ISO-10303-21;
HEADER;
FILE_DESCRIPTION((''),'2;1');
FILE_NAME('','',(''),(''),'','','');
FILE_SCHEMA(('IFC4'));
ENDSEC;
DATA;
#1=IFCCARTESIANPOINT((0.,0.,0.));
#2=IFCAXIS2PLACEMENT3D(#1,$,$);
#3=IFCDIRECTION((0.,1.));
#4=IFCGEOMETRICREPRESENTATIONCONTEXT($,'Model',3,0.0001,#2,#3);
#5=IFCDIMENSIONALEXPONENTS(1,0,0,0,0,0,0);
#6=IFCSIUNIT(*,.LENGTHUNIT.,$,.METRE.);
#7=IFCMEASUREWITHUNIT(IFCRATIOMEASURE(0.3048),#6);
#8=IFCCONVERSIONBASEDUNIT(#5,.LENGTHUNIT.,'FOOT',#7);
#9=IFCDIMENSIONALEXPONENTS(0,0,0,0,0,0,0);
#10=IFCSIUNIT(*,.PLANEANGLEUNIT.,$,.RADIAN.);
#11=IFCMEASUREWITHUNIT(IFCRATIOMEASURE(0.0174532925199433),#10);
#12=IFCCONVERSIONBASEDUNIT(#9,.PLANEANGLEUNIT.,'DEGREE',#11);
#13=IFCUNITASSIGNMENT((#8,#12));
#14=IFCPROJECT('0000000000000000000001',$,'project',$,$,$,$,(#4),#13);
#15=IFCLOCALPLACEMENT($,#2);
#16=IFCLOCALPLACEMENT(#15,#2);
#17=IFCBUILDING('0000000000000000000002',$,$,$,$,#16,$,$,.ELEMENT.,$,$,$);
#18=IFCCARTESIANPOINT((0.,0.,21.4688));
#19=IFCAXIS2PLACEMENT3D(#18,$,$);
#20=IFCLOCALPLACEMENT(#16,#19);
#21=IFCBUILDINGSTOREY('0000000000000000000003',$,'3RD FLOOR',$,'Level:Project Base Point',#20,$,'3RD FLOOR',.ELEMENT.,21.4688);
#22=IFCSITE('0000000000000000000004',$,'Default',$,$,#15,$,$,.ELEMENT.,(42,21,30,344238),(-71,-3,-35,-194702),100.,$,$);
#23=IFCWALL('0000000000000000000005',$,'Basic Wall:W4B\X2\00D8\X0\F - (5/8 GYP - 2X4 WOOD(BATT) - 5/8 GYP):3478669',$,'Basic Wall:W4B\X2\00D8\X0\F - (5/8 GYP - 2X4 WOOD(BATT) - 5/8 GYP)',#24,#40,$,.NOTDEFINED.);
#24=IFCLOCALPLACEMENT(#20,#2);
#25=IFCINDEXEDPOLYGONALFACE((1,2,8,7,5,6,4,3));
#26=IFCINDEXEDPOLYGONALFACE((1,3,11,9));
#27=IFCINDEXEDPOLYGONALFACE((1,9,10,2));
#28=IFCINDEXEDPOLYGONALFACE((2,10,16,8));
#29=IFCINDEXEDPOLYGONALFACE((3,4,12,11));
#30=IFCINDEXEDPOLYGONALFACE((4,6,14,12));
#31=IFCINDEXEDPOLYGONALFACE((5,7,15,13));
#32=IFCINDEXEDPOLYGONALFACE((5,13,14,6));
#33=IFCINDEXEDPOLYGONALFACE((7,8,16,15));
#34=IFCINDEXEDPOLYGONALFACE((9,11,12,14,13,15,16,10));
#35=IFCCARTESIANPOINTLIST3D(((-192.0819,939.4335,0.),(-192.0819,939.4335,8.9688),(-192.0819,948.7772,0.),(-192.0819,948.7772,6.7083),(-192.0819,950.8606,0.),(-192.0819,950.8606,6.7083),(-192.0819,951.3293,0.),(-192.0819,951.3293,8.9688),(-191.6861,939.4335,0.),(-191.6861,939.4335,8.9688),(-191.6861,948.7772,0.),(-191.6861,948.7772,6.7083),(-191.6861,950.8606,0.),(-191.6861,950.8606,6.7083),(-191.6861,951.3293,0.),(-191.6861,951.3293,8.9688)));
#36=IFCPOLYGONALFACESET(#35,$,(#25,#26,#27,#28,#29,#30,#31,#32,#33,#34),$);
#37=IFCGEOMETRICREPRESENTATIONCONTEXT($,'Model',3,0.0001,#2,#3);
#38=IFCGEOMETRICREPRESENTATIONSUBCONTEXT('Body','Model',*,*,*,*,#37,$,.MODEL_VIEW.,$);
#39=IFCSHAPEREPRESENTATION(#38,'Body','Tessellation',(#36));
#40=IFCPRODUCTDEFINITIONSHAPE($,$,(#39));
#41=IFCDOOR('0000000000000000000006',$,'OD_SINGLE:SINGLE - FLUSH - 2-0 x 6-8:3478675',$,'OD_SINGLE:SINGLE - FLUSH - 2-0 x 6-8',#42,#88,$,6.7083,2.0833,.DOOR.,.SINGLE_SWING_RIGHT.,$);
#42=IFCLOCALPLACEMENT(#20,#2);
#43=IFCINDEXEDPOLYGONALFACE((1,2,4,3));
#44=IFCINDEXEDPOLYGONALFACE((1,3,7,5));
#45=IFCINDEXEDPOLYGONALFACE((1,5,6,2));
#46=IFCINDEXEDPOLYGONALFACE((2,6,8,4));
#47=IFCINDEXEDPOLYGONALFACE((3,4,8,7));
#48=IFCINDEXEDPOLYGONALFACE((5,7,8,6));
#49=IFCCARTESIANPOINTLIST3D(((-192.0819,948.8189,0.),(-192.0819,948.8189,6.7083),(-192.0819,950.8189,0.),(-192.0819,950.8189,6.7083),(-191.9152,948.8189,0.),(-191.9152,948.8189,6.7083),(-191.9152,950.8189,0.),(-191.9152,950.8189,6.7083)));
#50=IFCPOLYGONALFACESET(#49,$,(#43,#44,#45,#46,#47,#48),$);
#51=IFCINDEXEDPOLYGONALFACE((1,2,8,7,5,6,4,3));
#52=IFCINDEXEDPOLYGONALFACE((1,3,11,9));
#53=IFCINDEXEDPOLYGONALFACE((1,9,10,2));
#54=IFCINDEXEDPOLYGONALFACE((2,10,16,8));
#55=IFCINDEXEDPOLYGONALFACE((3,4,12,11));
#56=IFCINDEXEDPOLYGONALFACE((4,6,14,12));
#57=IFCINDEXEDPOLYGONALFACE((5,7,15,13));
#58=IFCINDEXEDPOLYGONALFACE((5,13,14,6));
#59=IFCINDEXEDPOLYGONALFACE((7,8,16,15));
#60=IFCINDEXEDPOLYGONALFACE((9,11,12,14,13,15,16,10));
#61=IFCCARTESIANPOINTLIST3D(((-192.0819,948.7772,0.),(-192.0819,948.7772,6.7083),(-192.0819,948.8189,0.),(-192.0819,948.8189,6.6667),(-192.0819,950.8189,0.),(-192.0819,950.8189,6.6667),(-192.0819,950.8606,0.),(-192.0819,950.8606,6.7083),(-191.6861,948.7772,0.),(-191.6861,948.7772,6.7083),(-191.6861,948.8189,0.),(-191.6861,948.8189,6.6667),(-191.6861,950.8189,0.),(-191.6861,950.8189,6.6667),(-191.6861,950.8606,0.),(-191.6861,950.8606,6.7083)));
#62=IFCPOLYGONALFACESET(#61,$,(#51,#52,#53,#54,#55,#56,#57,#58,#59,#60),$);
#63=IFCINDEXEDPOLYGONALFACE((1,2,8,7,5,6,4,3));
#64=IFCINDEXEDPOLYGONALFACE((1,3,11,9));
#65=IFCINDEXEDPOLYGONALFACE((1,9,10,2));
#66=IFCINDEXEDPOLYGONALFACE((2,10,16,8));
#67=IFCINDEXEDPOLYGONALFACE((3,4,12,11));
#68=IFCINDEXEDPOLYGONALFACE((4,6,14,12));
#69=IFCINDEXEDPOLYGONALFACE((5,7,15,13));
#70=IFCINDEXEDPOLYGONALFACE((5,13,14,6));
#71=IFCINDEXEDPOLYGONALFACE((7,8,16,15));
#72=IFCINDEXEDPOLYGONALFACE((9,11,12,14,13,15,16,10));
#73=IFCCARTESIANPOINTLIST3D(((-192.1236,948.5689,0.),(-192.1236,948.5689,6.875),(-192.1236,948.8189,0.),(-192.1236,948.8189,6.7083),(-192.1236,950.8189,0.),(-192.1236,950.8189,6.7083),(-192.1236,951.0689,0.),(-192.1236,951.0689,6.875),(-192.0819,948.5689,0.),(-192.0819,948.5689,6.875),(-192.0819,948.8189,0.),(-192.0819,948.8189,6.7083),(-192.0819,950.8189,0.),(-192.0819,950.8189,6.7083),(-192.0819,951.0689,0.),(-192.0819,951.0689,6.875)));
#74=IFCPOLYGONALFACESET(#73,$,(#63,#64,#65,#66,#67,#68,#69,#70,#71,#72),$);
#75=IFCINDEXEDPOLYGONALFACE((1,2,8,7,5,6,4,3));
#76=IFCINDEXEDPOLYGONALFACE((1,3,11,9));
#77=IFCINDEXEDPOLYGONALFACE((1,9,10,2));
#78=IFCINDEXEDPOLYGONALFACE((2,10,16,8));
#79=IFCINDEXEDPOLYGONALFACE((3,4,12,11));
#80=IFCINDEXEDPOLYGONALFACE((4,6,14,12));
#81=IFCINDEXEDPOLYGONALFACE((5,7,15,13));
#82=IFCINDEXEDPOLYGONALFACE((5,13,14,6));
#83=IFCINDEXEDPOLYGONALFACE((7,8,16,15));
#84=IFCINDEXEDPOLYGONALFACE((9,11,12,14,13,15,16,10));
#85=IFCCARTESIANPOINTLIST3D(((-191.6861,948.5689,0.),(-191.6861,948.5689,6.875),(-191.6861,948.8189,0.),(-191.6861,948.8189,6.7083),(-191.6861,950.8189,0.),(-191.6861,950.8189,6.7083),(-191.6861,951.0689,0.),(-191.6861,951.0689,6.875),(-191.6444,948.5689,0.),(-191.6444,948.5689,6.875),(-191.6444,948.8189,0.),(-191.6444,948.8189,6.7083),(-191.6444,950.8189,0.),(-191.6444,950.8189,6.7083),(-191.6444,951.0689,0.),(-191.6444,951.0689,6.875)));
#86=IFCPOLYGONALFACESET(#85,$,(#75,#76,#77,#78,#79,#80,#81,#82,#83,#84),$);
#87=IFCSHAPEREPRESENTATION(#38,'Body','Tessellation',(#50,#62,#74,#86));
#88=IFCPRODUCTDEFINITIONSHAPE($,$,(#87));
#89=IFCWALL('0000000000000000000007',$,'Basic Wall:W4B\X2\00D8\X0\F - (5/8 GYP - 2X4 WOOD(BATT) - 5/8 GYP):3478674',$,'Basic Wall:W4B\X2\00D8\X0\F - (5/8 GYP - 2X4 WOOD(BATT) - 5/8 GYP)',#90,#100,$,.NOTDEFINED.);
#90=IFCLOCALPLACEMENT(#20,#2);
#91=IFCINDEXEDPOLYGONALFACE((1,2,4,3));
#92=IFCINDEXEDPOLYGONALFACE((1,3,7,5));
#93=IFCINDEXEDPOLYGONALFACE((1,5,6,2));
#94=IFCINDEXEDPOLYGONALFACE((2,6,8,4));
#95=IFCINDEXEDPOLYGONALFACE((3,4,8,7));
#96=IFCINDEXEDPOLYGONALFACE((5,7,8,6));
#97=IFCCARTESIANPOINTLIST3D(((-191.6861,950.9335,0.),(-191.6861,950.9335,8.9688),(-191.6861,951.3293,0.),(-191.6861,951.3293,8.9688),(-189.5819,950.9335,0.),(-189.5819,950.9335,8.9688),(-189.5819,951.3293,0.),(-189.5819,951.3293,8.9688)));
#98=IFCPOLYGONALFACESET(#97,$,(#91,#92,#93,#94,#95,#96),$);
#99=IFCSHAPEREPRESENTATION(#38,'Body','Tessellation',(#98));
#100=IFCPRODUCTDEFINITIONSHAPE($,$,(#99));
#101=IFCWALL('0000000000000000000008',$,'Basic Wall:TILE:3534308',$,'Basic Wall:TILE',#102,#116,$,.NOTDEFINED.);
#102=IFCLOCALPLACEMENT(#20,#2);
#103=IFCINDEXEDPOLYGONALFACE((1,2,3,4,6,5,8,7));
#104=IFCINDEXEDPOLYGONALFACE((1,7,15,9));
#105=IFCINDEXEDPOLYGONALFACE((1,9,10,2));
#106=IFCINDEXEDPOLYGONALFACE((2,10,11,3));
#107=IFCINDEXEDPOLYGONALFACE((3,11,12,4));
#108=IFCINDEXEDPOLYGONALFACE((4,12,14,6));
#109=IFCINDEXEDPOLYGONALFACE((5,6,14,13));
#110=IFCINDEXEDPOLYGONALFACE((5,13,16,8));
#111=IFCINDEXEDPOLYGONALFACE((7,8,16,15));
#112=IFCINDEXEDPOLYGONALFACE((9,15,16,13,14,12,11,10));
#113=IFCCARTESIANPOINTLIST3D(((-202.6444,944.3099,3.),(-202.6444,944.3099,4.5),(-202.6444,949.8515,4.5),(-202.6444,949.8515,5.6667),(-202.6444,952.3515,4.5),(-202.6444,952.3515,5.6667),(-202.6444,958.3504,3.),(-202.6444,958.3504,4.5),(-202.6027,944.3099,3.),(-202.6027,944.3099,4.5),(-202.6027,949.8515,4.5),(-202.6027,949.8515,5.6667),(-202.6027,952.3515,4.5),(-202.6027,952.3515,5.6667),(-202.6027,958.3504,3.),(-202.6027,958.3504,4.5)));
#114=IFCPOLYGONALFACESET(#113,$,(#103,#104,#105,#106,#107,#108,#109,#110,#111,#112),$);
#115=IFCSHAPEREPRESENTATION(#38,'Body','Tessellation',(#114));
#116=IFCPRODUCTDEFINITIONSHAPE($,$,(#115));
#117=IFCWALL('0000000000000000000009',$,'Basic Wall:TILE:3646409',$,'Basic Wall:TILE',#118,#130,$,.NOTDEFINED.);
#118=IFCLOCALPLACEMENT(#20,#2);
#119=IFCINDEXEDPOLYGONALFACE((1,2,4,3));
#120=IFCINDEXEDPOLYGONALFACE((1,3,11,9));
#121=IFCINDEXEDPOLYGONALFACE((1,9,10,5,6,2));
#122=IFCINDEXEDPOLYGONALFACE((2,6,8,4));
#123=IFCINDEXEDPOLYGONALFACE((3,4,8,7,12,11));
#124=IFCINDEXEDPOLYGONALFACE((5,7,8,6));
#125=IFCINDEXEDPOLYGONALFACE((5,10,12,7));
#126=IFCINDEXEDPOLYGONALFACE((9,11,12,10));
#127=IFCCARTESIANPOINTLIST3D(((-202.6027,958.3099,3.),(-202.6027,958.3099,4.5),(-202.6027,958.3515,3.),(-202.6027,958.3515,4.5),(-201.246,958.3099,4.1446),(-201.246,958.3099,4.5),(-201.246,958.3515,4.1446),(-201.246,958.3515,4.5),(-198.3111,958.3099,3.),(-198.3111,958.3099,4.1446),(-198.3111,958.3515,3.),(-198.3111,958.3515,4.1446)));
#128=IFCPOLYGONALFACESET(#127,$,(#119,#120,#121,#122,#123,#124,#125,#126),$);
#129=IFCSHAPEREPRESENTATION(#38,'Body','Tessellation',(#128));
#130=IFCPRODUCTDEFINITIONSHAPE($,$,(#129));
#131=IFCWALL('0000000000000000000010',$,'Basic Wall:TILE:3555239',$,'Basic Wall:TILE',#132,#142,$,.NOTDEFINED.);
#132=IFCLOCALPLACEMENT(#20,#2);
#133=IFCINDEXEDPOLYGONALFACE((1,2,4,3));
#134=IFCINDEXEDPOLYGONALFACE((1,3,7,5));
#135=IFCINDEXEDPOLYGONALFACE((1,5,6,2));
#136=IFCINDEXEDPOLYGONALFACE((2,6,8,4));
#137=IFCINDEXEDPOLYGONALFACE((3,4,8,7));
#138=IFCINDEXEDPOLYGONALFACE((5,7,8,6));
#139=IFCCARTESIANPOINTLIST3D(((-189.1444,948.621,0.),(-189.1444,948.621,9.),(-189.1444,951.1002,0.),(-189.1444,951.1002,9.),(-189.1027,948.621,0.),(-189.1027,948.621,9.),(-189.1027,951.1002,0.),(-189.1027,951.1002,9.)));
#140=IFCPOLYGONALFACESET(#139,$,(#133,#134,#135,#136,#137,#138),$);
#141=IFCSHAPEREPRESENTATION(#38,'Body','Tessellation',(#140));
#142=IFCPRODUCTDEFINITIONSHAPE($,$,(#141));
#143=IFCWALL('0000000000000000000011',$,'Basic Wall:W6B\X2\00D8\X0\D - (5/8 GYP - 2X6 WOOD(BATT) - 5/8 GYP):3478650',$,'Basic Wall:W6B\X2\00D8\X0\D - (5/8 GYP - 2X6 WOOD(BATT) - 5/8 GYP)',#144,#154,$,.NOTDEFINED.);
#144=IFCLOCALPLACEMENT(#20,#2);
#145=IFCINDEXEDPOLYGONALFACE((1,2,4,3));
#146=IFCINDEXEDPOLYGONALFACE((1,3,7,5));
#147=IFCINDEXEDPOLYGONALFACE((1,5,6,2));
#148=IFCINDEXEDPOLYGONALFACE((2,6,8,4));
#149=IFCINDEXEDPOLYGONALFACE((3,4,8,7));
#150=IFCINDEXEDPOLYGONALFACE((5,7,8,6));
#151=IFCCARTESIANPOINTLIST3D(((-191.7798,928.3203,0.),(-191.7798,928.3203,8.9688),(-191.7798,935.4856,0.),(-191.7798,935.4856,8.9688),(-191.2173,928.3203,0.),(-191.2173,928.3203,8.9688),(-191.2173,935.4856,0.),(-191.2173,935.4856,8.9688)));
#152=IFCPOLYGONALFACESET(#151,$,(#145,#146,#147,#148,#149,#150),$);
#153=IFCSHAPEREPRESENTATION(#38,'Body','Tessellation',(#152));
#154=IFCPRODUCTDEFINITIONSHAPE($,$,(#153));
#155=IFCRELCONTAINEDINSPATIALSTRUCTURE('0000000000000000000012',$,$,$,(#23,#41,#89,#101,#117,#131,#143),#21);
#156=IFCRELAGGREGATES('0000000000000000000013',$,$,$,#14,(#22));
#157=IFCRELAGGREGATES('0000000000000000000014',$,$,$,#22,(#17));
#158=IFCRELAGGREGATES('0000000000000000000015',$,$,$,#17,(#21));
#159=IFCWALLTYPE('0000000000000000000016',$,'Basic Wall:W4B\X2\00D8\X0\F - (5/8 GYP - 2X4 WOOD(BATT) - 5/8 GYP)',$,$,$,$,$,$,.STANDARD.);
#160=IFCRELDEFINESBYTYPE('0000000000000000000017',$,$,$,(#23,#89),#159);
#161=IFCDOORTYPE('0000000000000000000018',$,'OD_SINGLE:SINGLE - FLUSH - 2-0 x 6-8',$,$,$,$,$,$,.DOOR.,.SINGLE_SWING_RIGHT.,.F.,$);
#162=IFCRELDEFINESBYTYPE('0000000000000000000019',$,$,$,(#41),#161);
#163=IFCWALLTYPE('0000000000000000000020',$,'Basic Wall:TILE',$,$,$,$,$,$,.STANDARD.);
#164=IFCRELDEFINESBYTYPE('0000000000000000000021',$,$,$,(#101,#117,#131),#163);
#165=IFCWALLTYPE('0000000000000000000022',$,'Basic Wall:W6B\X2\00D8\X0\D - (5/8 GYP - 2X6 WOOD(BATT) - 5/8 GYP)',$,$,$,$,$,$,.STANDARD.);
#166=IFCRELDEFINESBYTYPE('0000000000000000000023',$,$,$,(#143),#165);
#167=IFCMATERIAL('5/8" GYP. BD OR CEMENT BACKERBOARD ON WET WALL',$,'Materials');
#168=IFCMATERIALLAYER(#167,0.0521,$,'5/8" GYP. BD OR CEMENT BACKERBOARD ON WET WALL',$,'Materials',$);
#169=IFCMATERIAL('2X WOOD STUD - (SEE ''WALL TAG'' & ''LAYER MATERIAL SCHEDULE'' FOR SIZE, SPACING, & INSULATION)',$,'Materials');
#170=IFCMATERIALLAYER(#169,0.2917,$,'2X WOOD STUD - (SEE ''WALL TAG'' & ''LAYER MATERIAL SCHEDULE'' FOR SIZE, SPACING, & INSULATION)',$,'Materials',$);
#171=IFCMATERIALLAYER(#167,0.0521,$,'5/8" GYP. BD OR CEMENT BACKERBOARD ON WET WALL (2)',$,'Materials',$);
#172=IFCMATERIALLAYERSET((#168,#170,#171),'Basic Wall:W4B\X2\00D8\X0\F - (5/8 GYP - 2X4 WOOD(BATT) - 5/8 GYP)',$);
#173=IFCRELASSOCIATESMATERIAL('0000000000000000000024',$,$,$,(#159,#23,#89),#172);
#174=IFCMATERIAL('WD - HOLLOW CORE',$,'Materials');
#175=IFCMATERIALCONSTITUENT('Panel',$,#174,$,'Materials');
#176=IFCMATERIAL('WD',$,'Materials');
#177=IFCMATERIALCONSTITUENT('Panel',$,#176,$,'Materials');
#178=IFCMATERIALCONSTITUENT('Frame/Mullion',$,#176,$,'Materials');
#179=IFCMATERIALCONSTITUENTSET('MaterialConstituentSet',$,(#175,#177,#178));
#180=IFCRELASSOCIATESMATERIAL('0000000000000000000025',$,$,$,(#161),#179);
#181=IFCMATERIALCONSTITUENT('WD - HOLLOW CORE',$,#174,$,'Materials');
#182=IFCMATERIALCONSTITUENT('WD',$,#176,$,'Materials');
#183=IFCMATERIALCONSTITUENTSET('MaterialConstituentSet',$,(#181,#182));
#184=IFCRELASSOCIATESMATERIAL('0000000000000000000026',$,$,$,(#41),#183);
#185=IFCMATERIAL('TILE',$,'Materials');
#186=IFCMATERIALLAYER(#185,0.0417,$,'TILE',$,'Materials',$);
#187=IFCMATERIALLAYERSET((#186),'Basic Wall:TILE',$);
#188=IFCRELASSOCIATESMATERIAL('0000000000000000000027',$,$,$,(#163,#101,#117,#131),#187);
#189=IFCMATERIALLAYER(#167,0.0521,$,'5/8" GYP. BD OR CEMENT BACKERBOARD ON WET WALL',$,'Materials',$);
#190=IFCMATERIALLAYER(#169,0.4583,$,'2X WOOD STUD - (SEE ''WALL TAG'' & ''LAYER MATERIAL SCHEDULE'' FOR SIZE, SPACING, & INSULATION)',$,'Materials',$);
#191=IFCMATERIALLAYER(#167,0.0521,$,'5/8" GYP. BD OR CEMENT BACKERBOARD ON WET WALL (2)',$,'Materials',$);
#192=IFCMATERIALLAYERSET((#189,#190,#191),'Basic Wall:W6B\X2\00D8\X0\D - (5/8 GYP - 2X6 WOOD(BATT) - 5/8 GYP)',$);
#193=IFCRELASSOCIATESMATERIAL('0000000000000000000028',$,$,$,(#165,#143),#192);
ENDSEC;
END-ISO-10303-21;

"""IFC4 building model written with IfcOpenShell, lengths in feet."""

from ifc_helpers import new_model, entity, si_unit, converted_unit, direction, frame, frame_2d, origin, origin_2d_with_axis, place, context, subcontext, project, spatial, polyline, rectangle, outline, extrude, source, transform, mapped, material, layer, layer_set, layer_usage, constituent, constituent_set, type_object, type_shapes, element, fill, save


model = new_model("IFC4")

# Units and contexts
model_context_1 = context("Model", 3, precision=0.0001, world=origin(), true_north=direction((0.0, 1.0)))
model_context_2 = context("Model", 3, precision=0.0001, world=origin(), true_north=direction((0.0, 1.0)))
body_context = subcontext(model_context_2, "Body", "Model", "MODEL_VIEW")
ifc_project = project(units=[converted_unit("LENGTHUNIT", "FOOT", entity("IfcRatioMeasure", 0.3048), si_unit("LENGTHUNIT", "METRE"), dimensions=[1, 0, 0, 0, 0, 0, 0]), converted_unit("PLANEANGLEUNIT", "DEGREE", entity("IfcRatioMeasure", 0.0174532925199433), si_unit("PLANEANGLEUNIT", "RADIAN"), dimensions=[0, 0, 0, 0, 0, 0, 0])], contexts=[model_context_1])

# Site, building, storey
site_placement = place(None, origin())
site = spatial("IfcSite", under=ifc_project, at=site_placement, Name="Default", CompositionType="ELEMENT", RefLatitude=(42, 21, 30, 344238), RefLongitude=(-71, -3, -35, -194702), RefElevation=100.0)
building_placement = place(site_placement, origin())
building = spatial("IfcBuilding", under=site, at=building_placement, CompositionType="ELEMENT")
storey_placement = place(building_placement, frame((0.0, 0.0, 21.4688)))
storey = spatial("IfcBuildingStorey", under=building, at=storey_placement, Name="3RD FLOOR", ObjectType="Level:Project Base Point", LongName="3RD FLOOR", CompositionType="ELEMENT", Elevation=21.4688)

# Wall, opening, door
ifc_material_1 = material(Name="5/8\" GYP. BD OR CEMENT BACKERBOARD ON WET WALL", Category="Materials")
ifc_layer_1 = layer(ifc_material_1, 0.0521, Name="5/8\" GYP. BD OR CEMENT BACKERBOARD ON WET WALL", Category="Materials")
ifc_material_2 = material(Name="2X WOOD STUD - (SEE 'WALL TAG' & 'LAYER MATERIAL SCHEDULE' FOR SIZE, SPACING, & INSULATION)", Category="Materials")
ifc_layer_2 = layer(ifc_material_2, 0.2917, Name="2X WOOD STUD - (SEE 'WALL TAG' & 'LAYER MATERIAL SCHEDULE' FOR SIZE, SPACING, & INSULATION)", Category="Materials")
ifc_layer_3 = layer(ifc_material_1, 0.0521, Name="5/8\" GYP. BD OR CEMENT BACKERBOARD ON WET WALL (2)", Category="Materials")
ifc_layer_set_1 = layer_set([ifc_layer_1, ifc_layer_2, ifc_layer_3], Name="Basic Wall:W4BØF - (5/8 GYP - 2X4 WOOD(BATT) - 5/8 GYP)")
ifc_layer_usage_1 = layer_usage(ifc_layer_set_1, "AXIS2", "NEGATIVE", 0.1979)
wall_type_1 = type_object("IfcWallType", Name="Basic Wall:W4BØF - (5/8 GYP - 2X4 WOOD(BATT) - 5/8 GYP)", PredefinedType="STANDARD", material=ifc_layer_set_1)
wall_1_placement = place(storey_placement, frame((-191.884, 939.4335, 0.0), z_axis=(0.0, 0.0, 1.0), x_axis=(0.0, 1.0, 0.0)))
wall_1 = element("IfcWall", 1, at=wall_1_placement, inside=storey, type_object=wall_type_1, material=ifc_layer_usage_1, Name="Basic Wall:W4BØF - (5/8 GYP - 2X4 WOOD(BATT) - 5/8 GYP):3478669", ObjectType="Basic Wall:W4BØF - (5/8 GYP - 2X4 WOOD(BATT) - 5/8 GYP)", PredefinedType="NOTDEFINED", context=body_context, shape_type="SweptSolid", body=[
    extrude(rectangle(XDim=11.8958, YDim=0.3958, at=frame_2d((5.9479, 0.0), x_axis=(-1.0, 0.0))), origin(), (0.0, 0.0, 1.0), 8.9688),
])
opening_1_placement = place(wall_1_placement, frame((9.3438, -0.1979, 0.0)))
opening_1 = element("IfcOpeningElement", 2, at=opening_1_placement, cuts=wall_1, PredefinedType="OPENING", context=body_context, shape_type="SweptSolid", body=[
    extrude(rectangle(XDim=2.0833, YDim=6.7083, at=frame_2d((3.3542, 1.0417), x_axis=(0.0, 1.0))), frame((0.0, 0.0, 0.0), z_axis=(0.0, 1.0, 0.0), x_axis=(0.0, 0.0, 1.0)), (0.0, 0.0, 1.0), 0.3958),
])
ifc_material_3 = material(Name="WD - HOLLOW CORE", Category="Materials")
ifc_constituent_1 = constituent(ifc_material_3, Name="WD - HOLLOW CORE", Category="Materials")
ifc_material_4 = material(Name="WD", Category="Materials")
ifc_constituent_2 = constituent(ifc_material_4, Name="WD", Category="Materials")
ifc_constituent_set_1 = constituent_set(constituents=[ifc_constituent_1, ifc_constituent_2], Name="MaterialConstituentSet")
ifc_constituent_3 = constituent(ifc_material_3, Name="Panel", Category="Materials")
ifc_constituent_4 = constituent(ifc_material_4, Name="Panel", Category="Materials")
ifc_constituent_5 = constituent(ifc_material_4, Name="Frame/Mullion", Category="Materials")
ifc_constituent_set_2 = constituent_set(constituents=[ifc_constituent_3, ifc_constituent_4, ifc_constituent_5], Name="MaterialConstituentSet")
door_type_1 = type_object("IfcDoorType", Name="OD_SINGLE:SINGLE - FLUSH - 2-0 x 6-8", OperationType="SINGLE_SWING_RIGHT", ParameterTakesPrecedence=False, PredefinedType="DOOR", material=ifc_constituent_set_2)
shared_shape_1 = source(origin(), body_context, "Body", "SweptSolid", [
    extrude(rectangle(XDim=0.1667, YDim=2.0, at=origin_2d_with_axis()), frame((1.0417, 0.3125, 0.0), z_axis=(0.0, 0.0, 1.0), x_axis=(0.0, 1.0, 0.0)), (0.0, 0.0, 1.0), 6.7083),
    extrude(outline(polyline([(-3.3646, -1.0417), (3.3438, -1.0417), (3.3438, -1.0), (-3.3229, -1.0), (-3.3229, 1.0), (3.3438, 1.0), (3.3438, 1.0417), (-3.3646, 1.0417), (-3.3646, -1.0417)])), frame((1.0417, 0.0, 3.3438), z_axis=(0.0, 1.0, 0.0), x_axis=(0.0, 0.0, -1.0)), (0.0, 0.0, 1.0), 0.3958),
    extrude(outline(polyline([(-1.25, -3.4792), (1.25, -3.4792), (1.25, 3.3958), (1.0, 3.3958), (1.0, -3.3125), (-1.0, -3.3125), (-1.0, 3.3958), (-1.25, 3.3958), (-1.25, -3.4792)])), frame((1.0417, 0.3958, 3.3958), z_axis=(0.0, 1.0, 0.0), x_axis=(1.0, 0.0, 0.0)), (0.0, 0.0, 1.0), 0.0417),
    extrude(outline(polyline([(-3.4792, -1.25), (3.3958, -1.25), (3.3958, -1.0), (-3.3125, -1.0), (-3.3125, 1.0), (3.3958, 1.0), (3.3958, 1.25), (-3.4792, 1.25), (-3.4792, -1.25)])), frame((1.0417, -0.0417, 3.3958), z_axis=(0.0, 1.0, 0.0), x_axis=(0.0, 0.0, -1.0)), (0.0, 0.0, 1.0), 0.0417),
])
type_shapes(door_type_1, [shared_shape_1])
door_1_placement = place(opening_1_placement, origin())
door_1 = element("IfcDoor", 3, at=door_1_placement, inside=storey, type_object=door_type_1, material=ifc_constituent_set_1, Name="OD_SINGLE:SINGLE - FLUSH - 2-0 x 6-8:3478675", ObjectType="OD_SINGLE:SINGLE - FLUSH - 2-0 x 6-8", OperationType="SINGLE_SWING_RIGHT", OverallHeight=6.7083, OverallWidth=2.0833, PredefinedType="DOOR", context=body_context, shape_type="MappedRepresentation", body=[
    mapped(shared_shape_1, transform((0.0, 0.0, 0.0), scale=1.0)),
])
fill(opening_1, door_1)

# Wall
ifc_layer_usage_2 = layer_usage(ifc_layer_set_1, "AXIS2", "POSITIVE", -0.1979)
wall_2_placement = place(storey_placement, frame((-189.5819, 951.1314, 0.0), z_axis=(0.0, 0.0, 1.0), x_axis=(-1.0, 0.0, 0.0)))
element("IfcWall", 4, at=wall_2_placement, inside=storey, type_object=wall_type_1, material=ifc_layer_usage_2, Name="Basic Wall:W4BØF - (5/8 GYP - 2X4 WOOD(BATT) - 5/8 GYP):3478674", ObjectType="Basic Wall:W4BØF - (5/8 GYP - 2X4 WOOD(BATT) - 5/8 GYP)", PredefinedType="NOTDEFINED", context=body_context, shape_type="SweptSolid", body=[
    extrude(rectangle(XDim=2.1042, YDim=0.3958, at=frame_2d((1.0521, 0.0), x_axis=(-1.0, 0.0))), origin(), (0.0, 0.0, 1.0), 8.9688),
])

# Wall, openings
ifc_material_5 = material(Name="TILE", Category="Materials")
ifc_layer_4 = layer(ifc_material_5, 0.0417, Name="TILE", Category="Materials")
ifc_layer_set_2 = layer_set([ifc_layer_4], Name="Basic Wall:TILE")
ifc_layer_usage_3 = layer_usage(ifc_layer_set_2, "AXIS2", "POSITIVE", -0.0208)
wall_type_2 = type_object("IfcWallType", Name="Basic Wall:TILE", PredefinedType="STANDARD", material=ifc_layer_set_2)
wall_3_placement = place(storey_placement, frame((-202.6236, 958.3504, 3.0), z_axis=(0.0, 0.0, 1.0), x_axis=(0.0, -1.0, 0.0)))
wall_3 = element("IfcWall", 5, at=wall_3_placement, inside=storey, type_object=wall_type_2, material=ifc_layer_usage_3, Name="Basic Wall:TILE:3534308", ObjectType="Basic Wall:TILE", PredefinedType="NOTDEFINED", context=body_context, shape_type="SweptSolid", body=[
    extrude(rectangle(XDim=14.0406, YDim=0.0417, at=frame_2d((7.0203, 0.0), x_axis=(-1.0, 0.0))), origin(), (0.0, 0.0, 1.0), 2.6667),
])
opening_2_placement = place(wall_3_placement, origin())
element("IfcOpeningElement", 6, at=opening_2_placement, cuts=wall_3, PredefinedType="OPENING", context=body_context, shape_type="SweptSolid", body=[
    extrude(rectangle(XDim=1.1667, YDim=5.9989, at=frame_2d((0.0, 0.0), x_axis=(0.0, 1.0))), frame((2.9994, 0.0208, 2.0833), z_axis=(0.0, -1.0, 0.0), x_axis=(-1.0, 0.0, 0.0)), (0.0, 0.0, 1.0), 0.0417),
])
opening_3_placement = place(wall_3_placement, origin())
element("IfcOpeningElement", 7, at=opening_3_placement, cuts=wall_3, PredefinedType="OPENING", context=body_context, shape_type="SweptSolid", body=[
    extrude(rectangle(XDim=1.1667, YDim=5.5417, at=origin_2d_with_axis()), frame((11.2697, 0.0208, 2.0833), z_axis=(0.0, -1.0, 0.0), x_axis=(0.0, 0.0, 1.0)), (0.0, 0.0, 1.0), 0.0417),
])

# Wall, opening
ifc_layer_usage_4 = layer_usage(ifc_layer_set_2, "AXIS2", "NEGATIVE", 0.0208)
wall_4_placement = place(storey_placement, frame((-202.6027, 958.3307, 3.0)))
wall_4 = element("IfcWall", 8, at=wall_4_placement, inside=storey, type_object=wall_type_2, material=ifc_layer_usage_4, Name="Basic Wall:TILE:3646409", ObjectType="Basic Wall:TILE", PredefinedType="NOTDEFINED", context=body_context, shape_type="SweptSolid", body=[
    extrude(rectangle(XDim=4.2917, YDim=0.0417, at=frame_2d((2.1458, 0.0), x_axis=(-1.0, 0.0))), origin(), (0.0, 0.0, 1.0), 1.5),
])
opening_4_placement = place(wall_4_placement, origin())
element("IfcOpeningElement", 9, at=opening_4_placement, cuts=wall_4, PredefinedType="OPENING", context=body_context, shape_type="SweptSolid", body=[
    extrude(rectangle(XDim=0.3554, YDim=2.9349, at=frame_2d((0.0, 0.0), x_axis=(1.0, 0.0))), frame((2.8242, 0.0208, 1.3223), z_axis=(0.0, -1.0, 0.0), x_axis=(0.0, 0.0, 1.0)), (0.0, 0.0, 1.0), 0.0417),
])

# Walls
ifc_layer_usage_5 = layer_usage(ifc_layer_set_2, "AXIS2", "POSITIVE", -0.0208)
wall_5_placement = place(storey_placement, frame((-189.1236, 951.1002, 0.0), z_axis=(0.0, 0.0, 1.0), x_axis=(0.0, -1.0, 0.0)))
element("IfcWall", 10, at=wall_5_placement, inside=storey, type_object=wall_type_2, material=ifc_layer_usage_5, Name="Basic Wall:TILE:3555239", ObjectType="Basic Wall:TILE", PredefinedType="NOTDEFINED", context=body_context, shape_type="SweptSolid", body=[
    extrude(rectangle(XDim=2.4792, YDim=0.0417, at=frame_2d((1.2396, 0.0), x_axis=(-1.0, 0.0))), origin(), (0.0, 0.0, 1.0), 9.0),
])
ifc_layer_5 = layer(ifc_material_1, 0.0521, Name="5/8\" GYP. BD OR CEMENT BACKERBOARD ON WET WALL", Category="Materials")
ifc_layer_6 = layer(ifc_material_2, 0.4583, Name="2X WOOD STUD - (SEE 'WALL TAG' & 'LAYER MATERIAL SCHEDULE' FOR SIZE, SPACING, & INSULATION)", Category="Materials")
ifc_layer_7 = layer(ifc_material_1, 0.0521, Name="5/8\" GYP. BD OR CEMENT BACKERBOARD ON WET WALL (2)", Category="Materials")
ifc_layer_set_3 = layer_set([ifc_layer_5, ifc_layer_6, ifc_layer_7], Name="Basic Wall:W6BØD - (5/8 GYP - 2X6 WOOD(BATT) - 5/8 GYP)")
ifc_layer_usage_6 = layer_usage(ifc_layer_set_3, "AXIS2", "NEGATIVE", 0.2812)
wall_type_3 = type_object("IfcWallType", Name="Basic Wall:W6BØD - (5/8 GYP - 2X6 WOOD(BATT) - 5/8 GYP)", PredefinedType="STANDARD", material=ifc_layer_set_3)
wall_6_placement = place(storey_placement, frame((-191.4985, 928.3203, 0.0), z_axis=(0.0, 0.0, 1.0), x_axis=(0.0, 1.0, 0.0)))
element("IfcWall", 11, at=wall_6_placement, inside=storey, type_object=wall_type_3, material=ifc_layer_usage_6, Name="Basic Wall:W6BØD - (5/8 GYP - 2X6 WOOD(BATT) - 5/8 GYP):3478650", ObjectType="Basic Wall:W6BØD - (5/8 GYP - 2X6 WOOD(BATT) - 5/8 GYP)", PredefinedType="NOTDEFINED", context=body_context, shape_type="SweptSolid", body=[
    extrude(rectangle(XDim=7.1653, YDim=0.5625, at=frame_2d((3.5826, 0.0), x_axis=(-1.0, 0.0))), origin(), (0.0, 0.0, 1.0), 8.9688),
])

save(model, "model.ifc")
